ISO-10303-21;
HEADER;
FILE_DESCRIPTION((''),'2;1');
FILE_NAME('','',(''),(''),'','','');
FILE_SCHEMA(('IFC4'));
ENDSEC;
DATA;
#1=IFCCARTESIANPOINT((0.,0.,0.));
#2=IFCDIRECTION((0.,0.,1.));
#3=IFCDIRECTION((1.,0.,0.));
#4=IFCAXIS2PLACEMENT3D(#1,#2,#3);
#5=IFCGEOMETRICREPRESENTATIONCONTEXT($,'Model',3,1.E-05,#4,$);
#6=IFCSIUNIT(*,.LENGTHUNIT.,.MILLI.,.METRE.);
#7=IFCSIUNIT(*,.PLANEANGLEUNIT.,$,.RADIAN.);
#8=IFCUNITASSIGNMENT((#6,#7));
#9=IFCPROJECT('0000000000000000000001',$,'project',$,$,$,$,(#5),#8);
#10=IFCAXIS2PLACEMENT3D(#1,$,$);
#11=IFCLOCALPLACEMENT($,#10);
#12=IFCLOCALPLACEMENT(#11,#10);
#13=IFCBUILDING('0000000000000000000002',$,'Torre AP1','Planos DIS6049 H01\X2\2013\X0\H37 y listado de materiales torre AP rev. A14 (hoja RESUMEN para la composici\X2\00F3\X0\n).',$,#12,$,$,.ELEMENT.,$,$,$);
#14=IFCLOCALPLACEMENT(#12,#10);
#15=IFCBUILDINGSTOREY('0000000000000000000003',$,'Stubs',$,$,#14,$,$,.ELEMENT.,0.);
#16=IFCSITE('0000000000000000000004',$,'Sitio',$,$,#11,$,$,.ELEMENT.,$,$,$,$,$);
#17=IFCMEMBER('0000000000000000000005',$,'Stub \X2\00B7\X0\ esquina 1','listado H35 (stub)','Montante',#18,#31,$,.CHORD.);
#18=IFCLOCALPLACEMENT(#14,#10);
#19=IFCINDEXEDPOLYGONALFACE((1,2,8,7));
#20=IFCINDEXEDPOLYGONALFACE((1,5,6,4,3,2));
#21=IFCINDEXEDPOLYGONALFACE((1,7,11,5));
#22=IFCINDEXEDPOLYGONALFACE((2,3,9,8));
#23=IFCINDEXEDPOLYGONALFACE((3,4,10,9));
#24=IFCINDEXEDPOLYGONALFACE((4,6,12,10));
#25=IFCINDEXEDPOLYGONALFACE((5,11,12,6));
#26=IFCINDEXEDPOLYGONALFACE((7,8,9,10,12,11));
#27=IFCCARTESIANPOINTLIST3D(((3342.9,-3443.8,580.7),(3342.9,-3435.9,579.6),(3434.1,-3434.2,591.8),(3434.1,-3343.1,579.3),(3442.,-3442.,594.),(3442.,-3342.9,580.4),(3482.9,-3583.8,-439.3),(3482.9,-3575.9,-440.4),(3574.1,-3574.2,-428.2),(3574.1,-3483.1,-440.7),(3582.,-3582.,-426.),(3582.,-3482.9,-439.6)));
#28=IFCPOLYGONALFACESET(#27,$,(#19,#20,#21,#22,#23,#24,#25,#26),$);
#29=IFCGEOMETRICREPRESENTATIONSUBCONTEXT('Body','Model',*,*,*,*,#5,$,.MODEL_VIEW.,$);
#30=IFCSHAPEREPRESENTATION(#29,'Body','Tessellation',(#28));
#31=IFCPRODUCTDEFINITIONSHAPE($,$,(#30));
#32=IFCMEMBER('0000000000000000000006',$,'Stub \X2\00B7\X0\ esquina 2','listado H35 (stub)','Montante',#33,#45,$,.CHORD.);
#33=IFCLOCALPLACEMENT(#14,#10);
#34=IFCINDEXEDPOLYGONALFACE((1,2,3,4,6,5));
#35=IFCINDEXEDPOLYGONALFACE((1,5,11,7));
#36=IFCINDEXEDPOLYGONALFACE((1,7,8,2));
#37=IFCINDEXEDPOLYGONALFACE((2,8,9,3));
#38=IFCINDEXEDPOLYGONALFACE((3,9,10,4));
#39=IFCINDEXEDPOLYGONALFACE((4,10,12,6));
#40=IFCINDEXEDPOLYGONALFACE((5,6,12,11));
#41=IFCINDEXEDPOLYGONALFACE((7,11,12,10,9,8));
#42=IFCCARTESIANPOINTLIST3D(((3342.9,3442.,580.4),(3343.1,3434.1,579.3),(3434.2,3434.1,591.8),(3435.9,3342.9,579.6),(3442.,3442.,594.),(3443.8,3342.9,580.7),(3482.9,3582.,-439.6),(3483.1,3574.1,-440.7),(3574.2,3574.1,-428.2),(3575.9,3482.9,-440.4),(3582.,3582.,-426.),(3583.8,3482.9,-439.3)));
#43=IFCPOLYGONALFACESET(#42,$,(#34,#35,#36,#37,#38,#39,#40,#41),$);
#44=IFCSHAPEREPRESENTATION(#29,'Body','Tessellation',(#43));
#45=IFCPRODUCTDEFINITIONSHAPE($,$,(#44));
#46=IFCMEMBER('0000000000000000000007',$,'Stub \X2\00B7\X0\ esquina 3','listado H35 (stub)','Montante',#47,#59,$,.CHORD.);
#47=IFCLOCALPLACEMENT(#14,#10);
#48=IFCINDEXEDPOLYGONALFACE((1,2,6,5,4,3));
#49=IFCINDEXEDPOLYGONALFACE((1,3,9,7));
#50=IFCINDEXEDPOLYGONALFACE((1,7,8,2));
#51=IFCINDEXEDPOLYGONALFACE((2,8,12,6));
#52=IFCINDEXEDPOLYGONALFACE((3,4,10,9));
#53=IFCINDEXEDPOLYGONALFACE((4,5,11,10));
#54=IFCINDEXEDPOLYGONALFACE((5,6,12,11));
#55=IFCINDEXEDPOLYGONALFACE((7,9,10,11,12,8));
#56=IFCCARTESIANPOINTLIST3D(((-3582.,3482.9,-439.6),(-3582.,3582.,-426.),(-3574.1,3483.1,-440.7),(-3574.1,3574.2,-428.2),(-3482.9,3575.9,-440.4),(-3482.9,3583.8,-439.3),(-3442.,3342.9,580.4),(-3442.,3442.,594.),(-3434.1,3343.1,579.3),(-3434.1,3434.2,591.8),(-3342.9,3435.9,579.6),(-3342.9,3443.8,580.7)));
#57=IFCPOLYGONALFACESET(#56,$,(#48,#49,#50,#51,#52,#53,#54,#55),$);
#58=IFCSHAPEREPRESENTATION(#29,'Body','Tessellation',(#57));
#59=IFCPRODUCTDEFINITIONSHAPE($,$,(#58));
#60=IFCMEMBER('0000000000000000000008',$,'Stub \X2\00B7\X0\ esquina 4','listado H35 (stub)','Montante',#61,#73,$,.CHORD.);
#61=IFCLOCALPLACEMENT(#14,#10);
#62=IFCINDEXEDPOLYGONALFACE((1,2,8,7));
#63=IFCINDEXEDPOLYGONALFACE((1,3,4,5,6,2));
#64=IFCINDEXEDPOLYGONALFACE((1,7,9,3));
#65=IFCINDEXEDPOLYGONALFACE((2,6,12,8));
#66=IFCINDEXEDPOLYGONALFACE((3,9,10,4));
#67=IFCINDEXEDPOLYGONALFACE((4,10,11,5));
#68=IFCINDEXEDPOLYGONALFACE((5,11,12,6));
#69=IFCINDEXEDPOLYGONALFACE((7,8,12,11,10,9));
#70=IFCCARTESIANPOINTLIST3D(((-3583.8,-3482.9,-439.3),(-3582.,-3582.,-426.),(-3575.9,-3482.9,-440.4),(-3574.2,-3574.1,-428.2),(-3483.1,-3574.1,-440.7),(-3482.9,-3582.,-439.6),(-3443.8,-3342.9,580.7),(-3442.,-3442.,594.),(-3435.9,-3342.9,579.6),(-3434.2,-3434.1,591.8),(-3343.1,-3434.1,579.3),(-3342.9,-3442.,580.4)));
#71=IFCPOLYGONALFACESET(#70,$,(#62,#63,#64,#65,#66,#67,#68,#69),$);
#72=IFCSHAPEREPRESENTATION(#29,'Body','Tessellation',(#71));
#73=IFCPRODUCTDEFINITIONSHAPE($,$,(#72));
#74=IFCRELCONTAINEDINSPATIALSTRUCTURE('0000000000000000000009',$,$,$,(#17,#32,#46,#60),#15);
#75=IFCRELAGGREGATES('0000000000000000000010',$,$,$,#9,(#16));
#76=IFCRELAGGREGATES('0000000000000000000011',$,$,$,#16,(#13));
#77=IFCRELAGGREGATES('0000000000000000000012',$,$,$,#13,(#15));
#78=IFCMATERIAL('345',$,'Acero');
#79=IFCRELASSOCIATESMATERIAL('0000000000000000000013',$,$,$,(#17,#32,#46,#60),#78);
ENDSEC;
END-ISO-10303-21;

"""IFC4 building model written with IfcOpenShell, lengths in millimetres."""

from ifc_helpers import new_model, si_unit, frame, frame_2d, origin, origin_with_axes, place, context, subcontext, project, spatial, l_section, extrude, material, element, save


model = new_model("IFC4")

# Units and contexts
model_context = context("Model", 3, precision=1e-05, world=origin_with_axes())
body_context = subcontext(model_context, "Body", "Model", "MODEL_VIEW")
ifc_project = project(units=[si_unit("LENGTHUNIT", "METRE", prefix="MILLI"), si_unit("PLANEANGLEUNIT", "RADIAN")], contexts=[model_context])

# Site, building, storey
site_placement = place(None, origin())
site = spatial("IfcSite", under=ifc_project, at=site_placement, Name="Sitio", CompositionType="ELEMENT")
building_placement = place(site_placement, origin())
building = spatial("IfcBuilding", under=site, at=building_placement, Name="Torre AP1", Description="Planos DIS6049 H01–H37 y listado de materiales torre AP rev. A14 (hoja RESUMEN para la composición).", CompositionType="ELEMENT")
storey_placement = place(building_placement, origin())
storey = spatial("IfcBuildingStorey", under=building, at=storey_placement, Name="Stubs", CompositionType="ELEMENT", Elevation=0.0)

# Members
ifc_material = material(Name="345", Category="Acero")
for number, where, z_axis, x_axis, name in (
    (1, (3442.0, -3442.0, 594.0), (0.13474, -0.13474, -0.981677), (-0.990881, -0.018322, -0.133488), "Stub · esquina 1"),
    (2, (3442.0, 3442.0, 594.0), (0.13474, 0.13474, -0.981677), (0.018322, -0.990881, -0.133488), "Stub · esquina 2"),
    (3, (-3442.0, 3442.0, 594.0), (-0.13474, 0.13474, -0.981677), (0.990881, 0.018322, -0.133488), "Stub · esquina 3"),
    (4, (-3442.0, -3442.0, 594.0), (-0.13474, -0.13474, -0.981677), (-0.018322, 0.990881, -0.133488), "Stub · esquina 4"),
):
    element("IfcMember", number, at=place(storey_placement, frame(where, z_axis=z_axis, x_axis=x_axis)), inside=storey, material=ifc_material, Name=name, Description="listado H35 (stub)", ObjectType="Montante", PredefinedType="CHORD", context=body_context, shape_type="SweptSolid", body=[
        extrude(l_section(Depth=100.0, Width=100.0, Thickness=8.0, at=frame_2d((50.0, 50.0))), None, (0.0, 0.0, 1.0), 1039.0),
    ])

save(model, "model.ifc")
